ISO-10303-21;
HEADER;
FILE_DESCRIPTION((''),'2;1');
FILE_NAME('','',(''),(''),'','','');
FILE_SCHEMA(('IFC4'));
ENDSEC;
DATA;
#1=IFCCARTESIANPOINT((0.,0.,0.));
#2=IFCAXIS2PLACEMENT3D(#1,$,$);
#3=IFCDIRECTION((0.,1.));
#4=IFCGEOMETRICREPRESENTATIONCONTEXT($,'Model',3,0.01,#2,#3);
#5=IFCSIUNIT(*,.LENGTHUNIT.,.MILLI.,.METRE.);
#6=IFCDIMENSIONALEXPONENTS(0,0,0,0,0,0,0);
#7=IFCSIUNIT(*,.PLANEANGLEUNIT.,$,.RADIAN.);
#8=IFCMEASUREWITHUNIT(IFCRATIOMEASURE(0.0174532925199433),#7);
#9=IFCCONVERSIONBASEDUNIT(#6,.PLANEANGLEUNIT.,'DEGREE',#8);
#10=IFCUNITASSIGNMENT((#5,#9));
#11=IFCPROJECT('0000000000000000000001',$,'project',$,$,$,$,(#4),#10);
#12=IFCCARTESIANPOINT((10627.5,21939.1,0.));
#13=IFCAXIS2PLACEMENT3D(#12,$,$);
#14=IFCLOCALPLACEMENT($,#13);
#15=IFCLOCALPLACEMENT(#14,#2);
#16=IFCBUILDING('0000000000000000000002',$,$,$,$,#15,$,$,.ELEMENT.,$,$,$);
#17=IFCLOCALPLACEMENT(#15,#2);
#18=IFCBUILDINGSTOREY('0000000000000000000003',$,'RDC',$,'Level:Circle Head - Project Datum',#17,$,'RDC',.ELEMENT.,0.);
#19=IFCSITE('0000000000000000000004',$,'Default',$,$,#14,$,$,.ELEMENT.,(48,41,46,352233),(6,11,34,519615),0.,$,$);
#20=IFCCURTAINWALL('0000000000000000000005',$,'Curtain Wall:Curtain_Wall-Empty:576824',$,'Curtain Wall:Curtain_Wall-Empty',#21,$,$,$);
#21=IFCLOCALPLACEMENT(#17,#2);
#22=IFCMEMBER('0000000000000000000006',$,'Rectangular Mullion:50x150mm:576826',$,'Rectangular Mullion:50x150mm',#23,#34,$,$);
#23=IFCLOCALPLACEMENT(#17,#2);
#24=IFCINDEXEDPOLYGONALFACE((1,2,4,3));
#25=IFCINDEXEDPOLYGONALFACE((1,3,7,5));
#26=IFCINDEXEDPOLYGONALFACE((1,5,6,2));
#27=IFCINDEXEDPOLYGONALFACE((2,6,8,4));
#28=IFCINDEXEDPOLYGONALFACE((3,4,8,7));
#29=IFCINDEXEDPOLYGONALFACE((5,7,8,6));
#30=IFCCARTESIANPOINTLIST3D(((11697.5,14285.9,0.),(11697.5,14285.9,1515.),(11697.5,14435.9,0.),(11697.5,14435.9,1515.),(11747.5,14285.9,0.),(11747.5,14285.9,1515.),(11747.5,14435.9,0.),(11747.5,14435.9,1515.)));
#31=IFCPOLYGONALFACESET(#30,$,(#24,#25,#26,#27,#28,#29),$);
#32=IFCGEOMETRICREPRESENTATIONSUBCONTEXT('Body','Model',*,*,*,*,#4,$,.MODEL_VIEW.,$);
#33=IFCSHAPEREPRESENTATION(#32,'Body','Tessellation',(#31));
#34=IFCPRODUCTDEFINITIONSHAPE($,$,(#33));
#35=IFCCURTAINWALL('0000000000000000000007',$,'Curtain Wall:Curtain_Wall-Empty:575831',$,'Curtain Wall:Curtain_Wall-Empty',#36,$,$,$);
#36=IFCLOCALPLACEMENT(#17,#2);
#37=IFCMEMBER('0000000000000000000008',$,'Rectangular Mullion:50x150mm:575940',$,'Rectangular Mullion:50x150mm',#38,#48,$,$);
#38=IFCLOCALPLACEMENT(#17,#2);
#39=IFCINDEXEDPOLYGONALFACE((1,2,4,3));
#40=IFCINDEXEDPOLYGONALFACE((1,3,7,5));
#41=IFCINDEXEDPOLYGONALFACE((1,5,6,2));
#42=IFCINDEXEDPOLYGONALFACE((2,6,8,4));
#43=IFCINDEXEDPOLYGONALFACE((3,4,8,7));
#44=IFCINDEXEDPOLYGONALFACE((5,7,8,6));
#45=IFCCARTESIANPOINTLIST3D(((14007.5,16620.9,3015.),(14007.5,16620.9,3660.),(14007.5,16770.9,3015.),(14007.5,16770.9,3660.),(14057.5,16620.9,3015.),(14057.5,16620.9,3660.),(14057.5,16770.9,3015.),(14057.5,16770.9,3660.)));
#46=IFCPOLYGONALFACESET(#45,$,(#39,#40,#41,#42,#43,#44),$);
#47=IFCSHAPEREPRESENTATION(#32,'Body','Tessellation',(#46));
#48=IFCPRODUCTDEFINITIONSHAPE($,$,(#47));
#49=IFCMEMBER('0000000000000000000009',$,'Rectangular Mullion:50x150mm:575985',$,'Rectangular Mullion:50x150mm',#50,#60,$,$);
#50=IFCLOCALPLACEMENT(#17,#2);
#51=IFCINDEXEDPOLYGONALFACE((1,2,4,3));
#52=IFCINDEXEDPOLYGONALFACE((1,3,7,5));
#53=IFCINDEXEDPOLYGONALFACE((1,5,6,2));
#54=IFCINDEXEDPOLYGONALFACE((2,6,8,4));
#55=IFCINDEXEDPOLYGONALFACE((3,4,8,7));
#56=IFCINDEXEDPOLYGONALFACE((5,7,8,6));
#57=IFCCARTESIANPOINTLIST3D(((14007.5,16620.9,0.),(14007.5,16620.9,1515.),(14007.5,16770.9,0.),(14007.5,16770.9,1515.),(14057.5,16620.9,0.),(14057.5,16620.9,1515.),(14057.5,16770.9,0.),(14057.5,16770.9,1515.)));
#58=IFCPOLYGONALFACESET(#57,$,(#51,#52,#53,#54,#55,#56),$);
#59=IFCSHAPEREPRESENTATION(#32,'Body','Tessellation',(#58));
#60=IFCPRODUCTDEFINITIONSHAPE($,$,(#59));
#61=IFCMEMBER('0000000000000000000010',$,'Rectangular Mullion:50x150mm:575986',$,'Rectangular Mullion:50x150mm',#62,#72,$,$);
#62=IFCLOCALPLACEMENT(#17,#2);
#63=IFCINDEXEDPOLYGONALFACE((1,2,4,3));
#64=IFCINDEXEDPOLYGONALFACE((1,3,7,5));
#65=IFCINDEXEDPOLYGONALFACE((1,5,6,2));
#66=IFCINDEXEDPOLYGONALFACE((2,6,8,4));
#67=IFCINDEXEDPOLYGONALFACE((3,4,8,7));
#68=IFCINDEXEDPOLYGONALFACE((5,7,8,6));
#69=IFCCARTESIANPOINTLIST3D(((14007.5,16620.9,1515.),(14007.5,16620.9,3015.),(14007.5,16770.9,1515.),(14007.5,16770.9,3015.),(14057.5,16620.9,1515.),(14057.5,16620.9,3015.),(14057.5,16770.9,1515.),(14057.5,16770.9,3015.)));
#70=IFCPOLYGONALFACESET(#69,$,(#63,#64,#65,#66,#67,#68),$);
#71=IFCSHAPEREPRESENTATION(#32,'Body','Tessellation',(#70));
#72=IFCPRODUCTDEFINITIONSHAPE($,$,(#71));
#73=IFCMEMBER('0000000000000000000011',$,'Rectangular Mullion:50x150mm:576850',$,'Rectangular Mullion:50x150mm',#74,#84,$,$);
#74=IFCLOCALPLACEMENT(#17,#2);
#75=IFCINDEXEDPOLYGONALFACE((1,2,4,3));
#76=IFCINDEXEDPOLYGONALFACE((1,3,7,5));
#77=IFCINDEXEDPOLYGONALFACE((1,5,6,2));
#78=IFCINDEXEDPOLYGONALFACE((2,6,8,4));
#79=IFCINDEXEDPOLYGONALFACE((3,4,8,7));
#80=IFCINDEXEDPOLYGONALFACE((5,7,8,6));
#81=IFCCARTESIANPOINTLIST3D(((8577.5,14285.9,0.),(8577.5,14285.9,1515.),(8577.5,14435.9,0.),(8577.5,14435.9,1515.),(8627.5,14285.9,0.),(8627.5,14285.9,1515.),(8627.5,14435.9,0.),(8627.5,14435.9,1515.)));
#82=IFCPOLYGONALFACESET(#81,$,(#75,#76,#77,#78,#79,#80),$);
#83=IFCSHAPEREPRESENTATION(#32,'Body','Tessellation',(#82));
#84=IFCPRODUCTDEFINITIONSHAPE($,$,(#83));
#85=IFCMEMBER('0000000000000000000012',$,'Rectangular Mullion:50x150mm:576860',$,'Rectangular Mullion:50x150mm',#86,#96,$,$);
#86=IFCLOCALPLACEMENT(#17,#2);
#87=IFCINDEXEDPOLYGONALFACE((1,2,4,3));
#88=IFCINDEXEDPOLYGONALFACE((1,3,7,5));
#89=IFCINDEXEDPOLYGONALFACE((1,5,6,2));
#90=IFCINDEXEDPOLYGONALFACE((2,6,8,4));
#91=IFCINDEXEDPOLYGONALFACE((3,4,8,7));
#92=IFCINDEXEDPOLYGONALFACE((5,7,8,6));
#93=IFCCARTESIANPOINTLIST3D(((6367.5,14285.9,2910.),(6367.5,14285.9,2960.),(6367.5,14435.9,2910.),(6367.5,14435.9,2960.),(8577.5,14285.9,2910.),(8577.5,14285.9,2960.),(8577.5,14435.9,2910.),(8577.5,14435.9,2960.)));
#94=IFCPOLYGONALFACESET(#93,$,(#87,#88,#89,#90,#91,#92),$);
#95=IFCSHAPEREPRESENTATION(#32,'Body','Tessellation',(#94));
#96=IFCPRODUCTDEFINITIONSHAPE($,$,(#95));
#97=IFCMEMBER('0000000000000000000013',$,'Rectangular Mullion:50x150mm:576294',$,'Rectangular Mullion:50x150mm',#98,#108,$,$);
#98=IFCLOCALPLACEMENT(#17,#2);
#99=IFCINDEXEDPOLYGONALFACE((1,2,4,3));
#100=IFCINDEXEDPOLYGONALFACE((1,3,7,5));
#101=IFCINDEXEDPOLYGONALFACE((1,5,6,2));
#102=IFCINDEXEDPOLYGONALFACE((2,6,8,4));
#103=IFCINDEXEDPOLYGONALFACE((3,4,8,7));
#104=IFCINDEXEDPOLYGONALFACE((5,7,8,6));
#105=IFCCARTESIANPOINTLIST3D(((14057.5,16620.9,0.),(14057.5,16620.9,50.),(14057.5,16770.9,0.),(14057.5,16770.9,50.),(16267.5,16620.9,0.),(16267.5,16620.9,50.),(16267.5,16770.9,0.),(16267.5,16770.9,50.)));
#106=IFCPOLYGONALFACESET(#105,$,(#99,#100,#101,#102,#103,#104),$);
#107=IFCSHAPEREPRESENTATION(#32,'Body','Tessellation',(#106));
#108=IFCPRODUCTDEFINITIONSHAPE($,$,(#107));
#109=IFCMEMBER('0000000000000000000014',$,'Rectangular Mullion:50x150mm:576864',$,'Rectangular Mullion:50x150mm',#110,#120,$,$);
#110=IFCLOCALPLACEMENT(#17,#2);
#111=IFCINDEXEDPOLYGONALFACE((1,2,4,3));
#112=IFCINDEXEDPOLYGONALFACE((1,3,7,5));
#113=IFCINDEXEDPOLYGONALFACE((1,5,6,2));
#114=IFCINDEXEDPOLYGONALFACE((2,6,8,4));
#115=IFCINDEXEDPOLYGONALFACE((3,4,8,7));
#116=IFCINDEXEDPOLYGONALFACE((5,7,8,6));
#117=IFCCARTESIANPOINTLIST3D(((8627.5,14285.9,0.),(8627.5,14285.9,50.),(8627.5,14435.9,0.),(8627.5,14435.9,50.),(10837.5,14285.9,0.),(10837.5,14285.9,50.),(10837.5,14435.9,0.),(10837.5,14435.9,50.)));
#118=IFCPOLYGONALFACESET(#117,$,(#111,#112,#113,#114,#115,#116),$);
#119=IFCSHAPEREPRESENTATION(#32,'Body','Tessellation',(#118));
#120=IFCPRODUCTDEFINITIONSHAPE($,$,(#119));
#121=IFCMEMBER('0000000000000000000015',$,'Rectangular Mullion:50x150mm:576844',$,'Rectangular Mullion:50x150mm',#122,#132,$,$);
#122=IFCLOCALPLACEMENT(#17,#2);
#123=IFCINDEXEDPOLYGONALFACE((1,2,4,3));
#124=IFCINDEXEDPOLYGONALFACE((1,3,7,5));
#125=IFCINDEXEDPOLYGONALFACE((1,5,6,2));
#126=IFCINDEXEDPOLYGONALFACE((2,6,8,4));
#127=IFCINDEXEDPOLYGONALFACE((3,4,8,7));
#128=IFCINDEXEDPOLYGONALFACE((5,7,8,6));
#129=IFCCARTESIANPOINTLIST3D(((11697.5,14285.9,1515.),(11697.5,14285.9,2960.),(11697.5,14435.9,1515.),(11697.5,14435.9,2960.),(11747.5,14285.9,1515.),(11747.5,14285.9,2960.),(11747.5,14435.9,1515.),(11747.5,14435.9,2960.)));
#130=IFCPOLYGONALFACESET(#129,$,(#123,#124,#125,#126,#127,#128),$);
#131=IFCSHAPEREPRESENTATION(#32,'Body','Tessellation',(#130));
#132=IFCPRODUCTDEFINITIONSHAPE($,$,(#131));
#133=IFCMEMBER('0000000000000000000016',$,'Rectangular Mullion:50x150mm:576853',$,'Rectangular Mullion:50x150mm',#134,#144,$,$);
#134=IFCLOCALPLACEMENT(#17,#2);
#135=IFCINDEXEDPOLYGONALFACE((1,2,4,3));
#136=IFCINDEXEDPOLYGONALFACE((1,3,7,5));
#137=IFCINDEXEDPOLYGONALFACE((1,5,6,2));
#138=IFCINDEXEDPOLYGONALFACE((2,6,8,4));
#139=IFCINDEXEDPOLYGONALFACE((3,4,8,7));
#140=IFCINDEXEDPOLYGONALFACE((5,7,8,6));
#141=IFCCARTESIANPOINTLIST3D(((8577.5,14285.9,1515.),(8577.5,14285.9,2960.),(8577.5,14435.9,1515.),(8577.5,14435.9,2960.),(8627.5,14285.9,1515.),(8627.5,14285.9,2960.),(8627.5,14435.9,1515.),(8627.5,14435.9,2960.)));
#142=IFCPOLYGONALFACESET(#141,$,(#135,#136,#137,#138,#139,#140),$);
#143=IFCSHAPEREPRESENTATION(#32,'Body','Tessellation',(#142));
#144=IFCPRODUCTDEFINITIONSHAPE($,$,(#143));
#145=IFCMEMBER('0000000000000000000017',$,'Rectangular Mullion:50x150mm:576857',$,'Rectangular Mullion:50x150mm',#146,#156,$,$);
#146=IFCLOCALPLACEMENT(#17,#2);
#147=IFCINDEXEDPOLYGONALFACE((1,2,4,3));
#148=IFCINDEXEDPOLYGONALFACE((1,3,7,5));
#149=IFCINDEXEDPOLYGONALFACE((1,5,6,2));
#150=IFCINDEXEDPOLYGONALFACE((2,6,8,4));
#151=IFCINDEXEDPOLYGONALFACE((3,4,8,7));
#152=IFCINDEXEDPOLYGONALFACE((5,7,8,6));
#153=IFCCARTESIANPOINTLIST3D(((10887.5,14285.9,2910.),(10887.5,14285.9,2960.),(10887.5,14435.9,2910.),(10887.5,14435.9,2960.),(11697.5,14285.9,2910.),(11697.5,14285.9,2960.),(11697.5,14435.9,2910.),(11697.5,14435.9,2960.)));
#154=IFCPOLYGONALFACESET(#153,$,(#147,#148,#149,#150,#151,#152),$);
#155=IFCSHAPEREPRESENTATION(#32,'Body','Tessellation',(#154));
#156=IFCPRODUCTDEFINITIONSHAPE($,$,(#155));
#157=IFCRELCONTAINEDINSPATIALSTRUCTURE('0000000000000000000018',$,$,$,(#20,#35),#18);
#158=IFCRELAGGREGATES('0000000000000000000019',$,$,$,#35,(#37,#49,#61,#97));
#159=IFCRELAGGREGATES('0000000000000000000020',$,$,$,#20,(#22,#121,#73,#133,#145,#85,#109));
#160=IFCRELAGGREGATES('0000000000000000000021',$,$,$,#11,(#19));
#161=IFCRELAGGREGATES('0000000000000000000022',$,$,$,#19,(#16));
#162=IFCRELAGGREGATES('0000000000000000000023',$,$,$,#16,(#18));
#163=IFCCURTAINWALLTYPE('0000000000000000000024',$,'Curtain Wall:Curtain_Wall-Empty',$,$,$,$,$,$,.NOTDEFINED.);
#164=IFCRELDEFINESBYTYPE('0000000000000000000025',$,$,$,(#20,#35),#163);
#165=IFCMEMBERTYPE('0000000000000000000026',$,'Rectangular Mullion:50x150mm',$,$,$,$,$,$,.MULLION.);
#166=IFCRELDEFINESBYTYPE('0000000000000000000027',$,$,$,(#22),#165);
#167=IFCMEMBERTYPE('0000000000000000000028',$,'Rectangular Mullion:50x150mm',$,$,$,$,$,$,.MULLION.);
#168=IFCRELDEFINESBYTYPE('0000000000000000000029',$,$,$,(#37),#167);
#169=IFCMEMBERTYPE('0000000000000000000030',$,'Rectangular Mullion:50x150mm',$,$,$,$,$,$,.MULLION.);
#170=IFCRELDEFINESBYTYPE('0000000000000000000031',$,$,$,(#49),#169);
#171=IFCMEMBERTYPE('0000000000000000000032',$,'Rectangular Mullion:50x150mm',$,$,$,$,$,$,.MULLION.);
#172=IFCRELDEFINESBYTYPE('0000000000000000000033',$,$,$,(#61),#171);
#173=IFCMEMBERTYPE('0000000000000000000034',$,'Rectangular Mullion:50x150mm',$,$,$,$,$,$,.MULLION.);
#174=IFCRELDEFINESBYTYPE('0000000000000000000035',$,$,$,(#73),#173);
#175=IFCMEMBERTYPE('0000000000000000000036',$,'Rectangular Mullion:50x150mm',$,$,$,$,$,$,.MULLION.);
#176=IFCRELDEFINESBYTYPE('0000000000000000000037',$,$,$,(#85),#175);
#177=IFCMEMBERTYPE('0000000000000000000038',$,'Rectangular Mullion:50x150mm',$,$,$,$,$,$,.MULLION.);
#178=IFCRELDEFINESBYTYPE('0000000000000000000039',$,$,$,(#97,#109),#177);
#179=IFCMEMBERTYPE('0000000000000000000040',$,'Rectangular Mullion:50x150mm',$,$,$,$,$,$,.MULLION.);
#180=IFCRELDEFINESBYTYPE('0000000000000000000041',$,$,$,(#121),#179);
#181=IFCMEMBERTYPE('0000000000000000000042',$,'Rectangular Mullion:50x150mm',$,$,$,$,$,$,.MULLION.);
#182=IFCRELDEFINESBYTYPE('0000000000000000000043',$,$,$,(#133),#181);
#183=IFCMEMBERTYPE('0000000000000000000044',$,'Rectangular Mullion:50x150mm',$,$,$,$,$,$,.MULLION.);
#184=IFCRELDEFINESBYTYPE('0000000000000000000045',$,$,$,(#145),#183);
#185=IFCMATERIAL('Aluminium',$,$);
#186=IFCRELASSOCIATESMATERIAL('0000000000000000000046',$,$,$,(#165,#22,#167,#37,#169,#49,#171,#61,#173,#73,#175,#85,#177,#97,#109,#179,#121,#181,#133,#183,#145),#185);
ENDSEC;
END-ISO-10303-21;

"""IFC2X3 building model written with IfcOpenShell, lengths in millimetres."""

from ifc_helpers import new_model, entity, si_unit, converted_unit, direction, frame, origin, origin_2d_with_axis, place, context, subcontext, project, spatial, rectangle, extrude, source, transform, mapped, material, type_object, type_shapes, element, aggregate, save


model = new_model("IFC2X3")

# Units and contexts
model_context = context("Model", 3, precision=0.01, world=origin(), true_north=direction((0.0, 1.0)))
body_context = subcontext(model_context, "Body", "Model", "MODEL_VIEW")
ifc_project = project(units=[si_unit("LENGTHUNIT", "METRE", prefix="MILLI"), converted_unit("PLANEANGLEUNIT", "DEGREE", entity("IfcRatioMeasure", 0.0174532925199433), si_unit("PLANEANGLEUNIT", "RADIAN"), dimensions=[0, 0, 0, 0, 0, 0, 0])], contexts=[model_context])

# Site, building, storey
site_placement = place(None, frame((10627.5, 21939.1, 0.0)))
site = spatial("IfcSite", under=ifc_project, at=site_placement, Name="Default", CompositionType="ELEMENT", RefLatitude=(48, 41, 46, 352233), RefLongitude=(6, 11, 34, 519615), RefElevation=0.0)
building_placement = place(site_placement, origin())
building = spatial("IfcBuilding", under=site, at=building_placement, CompositionType="ELEMENT")
storey_placement = place(building_placement, origin())
storey = spatial("IfcBuildingStorey", under=building, at=storey_placement, Name="RDC", ObjectType="Level:Circle Head - Project Datum", LongName="RDC", CompositionType="ELEMENT", Elevation=0.0)

# Curtain wall, member
curtain_wall_type = type_object("IfcCurtainWallType", Name="Curtain Wall:Curtain_Wall-Empty", PredefinedType="NOTDEFINED")
curtain_wall_1_placement = place(storey_placement, origin())
curtain_wall_1 = element("IfcCurtainWall", 1, at=curtain_wall_1_placement, inside=storey, type_object=curtain_wall_type, Name="Curtain Wall:Curtain_Wall-Empty:576824", ObjectType="Curtain Wall:Curtain_Wall-Empty")
ifc_material_1 = material(Name="Aluminium")
member_type_1 = type_object("IfcMemberType", Name="Rectangular Mullion:50x150mm", PredefinedType="MULLION", material=ifc_material_1)
shared_shape_1 = source(origin(), body_context, "Body", "SweptSolid", [
    extrude(rectangle(XDim=150.0, YDim=50.0, at=origin_2d_with_axis()), frame((-25.0, 0.0, -1515.0), z_axis=(0.0, 0.0, 1.0), x_axis=(0.0, -1.0, 0.0)), (0.0, 0.0, 1.0), 1515.0),
])
type_shapes(member_type_1, [shared_shape_1])
member_1_placement = place(storey_placement, frame((11747.5, 14360.9, 0.0), z_axis=(0.0, 0.0, -1.0), x_axis=(1.0, 0.0, 0.0)))
member_1 = element("IfcMember", 2, at=member_1_placement, type_object=member_type_1, material=ifc_material_1, Name="Rectangular Mullion:50x150mm:576826", ObjectType="Rectangular Mullion:50x150mm", context=body_context, shape_type="MappedRepresentation", body=[
    mapped(shared_shape_1, transform((0.0, 0.0, 0.0), scale=1.0)),
])

# Curtain wall, members
curtain_wall_2_placement = place(storey_placement, origin())
curtain_wall_2 = element("IfcCurtainWall", 3, at=curtain_wall_2_placement, inside=storey, type_object=curtain_wall_type, Name="Curtain Wall:Curtain_Wall-Empty:575831", ObjectType="Curtain Wall:Curtain_Wall-Empty")
member_type_2 = type_object("IfcMemberType", Name="Rectangular Mullion:50x150mm", PredefinedType="MULLION", material=ifc_material_1)
shared_shape_2 = source(origin(), body_context, "Body", "SweptSolid", [
    extrude(rectangle(XDim=150.0, YDim=50.0, at=origin_2d_with_axis()), frame((-25.0, 0.0, -645.0), z_axis=(0.0, 0.0, 1.0), x_axis=(0.0, -1.0, 0.0)), (0.0, 0.0, 1.0), 645.0),
])
type_shapes(member_type_2, [shared_shape_2])
member_2_placement = place(storey_placement, frame((14007.5, 16695.9, 3660.0), z_axis=(0.0, 0.0, 1.0), x_axis=(-1.0, 0.0, 0.0)))
member_2 = element("IfcMember", 4, at=member_2_placement, type_object=member_type_2, material=ifc_material_1, Name="Rectangular Mullion:50x150mm:575940", ObjectType="Rectangular Mullion:50x150mm", context=body_context, shape_type="MappedRepresentation", body=[
    mapped(shared_shape_2, transform((0.0, 0.0, 0.0), scale=1.0)),
])
member_type_3 = type_object("IfcMemberType", Name="Rectangular Mullion:50x150mm", PredefinedType="MULLION", material=ifc_material_1)
shared_shape_3 = source(origin(), body_context, "Body", "SweptSolid", [
    extrude(rectangle(XDim=150.0, YDim=50.0, at=origin_2d_with_axis()), frame((-25.0, 0.0, -1515.0), z_axis=(0.0, 0.0, 1.0), x_axis=(0.0, -1.0, 0.0)), (0.0, 0.0, 1.0), 1515.0),
])
type_shapes(member_type_3, [shared_shape_3])
member_3_placement = place(storey_placement, frame((14007.5, 16695.9, 1515.0), z_axis=(0.0, 0.0, 1.0), x_axis=(-1.0, 0.0, 0.0)))
member_3 = element("IfcMember", 5, at=member_3_placement, type_object=member_type_3, material=ifc_material_1, Name="Rectangular Mullion:50x150mm:575985", ObjectType="Rectangular Mullion:50x150mm", context=body_context, shape_type="MappedRepresentation", body=[
    mapped(shared_shape_3, transform((0.0, 0.0, 0.0), scale=1.0)),
])
member_type_4 = type_object("IfcMemberType", Name="Rectangular Mullion:50x150mm", PredefinedType="MULLION", material=ifc_material_1)
shared_shape_4 = source(origin(), body_context, "Body", "SweptSolid", [
    extrude(rectangle(XDim=150.0, YDim=50.0, at=origin_2d_with_axis()), frame((-25.0, 0.0, -1500.0), z_axis=(0.0, 0.0, 1.0), x_axis=(0.0, -1.0, 0.0)), (0.0, 0.0, 1.0), 1500.0),
])
type_shapes(member_type_4, [shared_shape_4])
member_4_placement = place(storey_placement, frame((14007.5, 16695.9, 3015.0), z_axis=(0.0, 0.0, 1.0), x_axis=(-1.0, 0.0, 0.0)))
member_4 = element("IfcMember", 6, at=member_4_placement, type_object=member_type_4, material=ifc_material_1, Name="Rectangular Mullion:50x150mm:575986", ObjectType="Rectangular Mullion:50x150mm", context=body_context, shape_type="MappedRepresentation", body=[
    mapped(shared_shape_4, transform((0.0, 0.0, 0.0), scale=1.0)),
])

# Members
member_type_5 = type_object("IfcMemberType", Name="Rectangular Mullion:50x150mm", PredefinedType="MULLION", material=ifc_material_1)
shared_shape_5 = source(origin(), body_context, "Body", "SweptSolid", [
    extrude(rectangle(XDim=150.0, YDim=50.0, at=origin_2d_with_axis()), frame((0.0, 0.0, -1515.0), z_axis=(0.0, 0.0, 1.0), x_axis=(0.0, -1.0, 0.0)), (0.0, 0.0, 1.0), 1515.0),
])
type_shapes(member_type_5, [shared_shape_5])
member_5_placement = place(storey_placement, frame((8602.5, 14360.9, 0.0), z_axis=(0.0, 0.0, -1.0), x_axis=(1.0, 0.0, 0.0)))
member_5 = element("IfcMember", 7, at=member_5_placement, type_object=member_type_5, material=ifc_material_1, Name="Rectangular Mullion:50x150mm:576850", ObjectType="Rectangular Mullion:50x150mm", context=body_context, shape_type="MappedRepresentation", body=[
    mapped(shared_shape_5, transform((0.0, 0.0, 0.0), scale=1.0)),
])
member_type_6 = type_object("IfcMemberType", Name="Rectangular Mullion:50x150mm", PredefinedType="MULLION", material=ifc_material_1)
shared_shape_6 = source(origin(), body_context, "Body", "SweptSolid", [
    extrude(rectangle(XDim=150.0, YDim=50.0, at=origin_2d_with_axis()), frame((-25.0, 0.0, -2210.0), z_axis=(0.0, 0.0, 1.0), x_axis=(0.0, -1.0, 0.0)), (0.0, 0.0, 1.0), 2210.0),
])
type_shapes(member_type_6, [shared_shape_6])
member_6_placement = place(storey_placement, frame((8577.5, 14360.9, 2960.0), z_axis=(1.0, 0.0, 0.0), x_axis=(0.0, 0.0, 1.0)))
member_6 = element("IfcMember", 8, at=member_6_placement, type_object=member_type_6, material=ifc_material_1, Name="Rectangular Mullion:50x150mm:576860", ObjectType="Rectangular Mullion:50x150mm", context=body_context, shape_type="MappedRepresentation", body=[
    mapped(shared_shape_6, transform((0.0, 0.0, 0.0), scale=1.0)),
])
member_type_7 = type_object("IfcMemberType", Name="Rectangular Mullion:50x150mm", PredefinedType="MULLION", material=ifc_material_1)
shared_shape_7 = source(origin(), body_context, "Body", "SweptSolid", [
    extrude(rectangle(XDim=150.0, YDim=50.0, at=origin_2d_with_axis()), frame((-25.0, 0.0, -2210.0), z_axis=(0.0, 0.0, 1.0), x_axis=(0.0, -1.0, 0.0)), (0.0, 0.0, 1.0), 2210.0),
])
type_shapes(member_type_7, [shared_shape_7])
member_7_placement = place(storey_placement, frame((14057.5, 16695.9, 0.0), z_axis=(-1.0, 0.0, 0.0), x_axis=(0.0, 0.0, -1.0)))
member_7 = element("IfcMember", 9, at=member_7_placement, type_object=member_type_7, material=ifc_material_1, Name="Rectangular Mullion:50x150mm:576294", ObjectType="Rectangular Mullion:50x150mm", context=body_context, shape_type="MappedRepresentation", body=[
    mapped(shared_shape_7, transform((0.0, 0.0, 0.0), scale=1.0)),
])
aggregate(curtain_wall_2, [member_2, member_3, member_4, member_7])
member_8_placement = place(storey_placement, frame((8627.5, 14360.9, 0.0), z_axis=(-1.0, 0.0, 0.0), x_axis=(0.0, 0.0, -1.0)))
member_8 = element("IfcMember", 10, at=member_8_placement, type_object=member_type_7, material=ifc_material_1, Name="Rectangular Mullion:50x150mm:576864", ObjectType="Rectangular Mullion:50x150mm", context=body_context, shape_type="MappedRepresentation", body=[
    mapped(shared_shape_7, transform((0.0, 0.0, 0.0), scale=1.0)),
])
member_type_8 = type_object("IfcMemberType", Name="Rectangular Mullion:50x150mm", PredefinedType="MULLION", material=ifc_material_1)
shared_shape_8 = source(origin(), body_context, "Body", "SweptSolid", [
    extrude(rectangle(XDim=150.0, YDim=50.0, at=origin_2d_with_axis()), frame((-25.0, 0.0, -1445.0), z_axis=(0.0, 0.0, 1.0), x_axis=(0.0, -1.0, 0.0)), (0.0, 0.0, 1.0), 1445.0),
])
type_shapes(member_type_8, [shared_shape_8])
member_9_placement = place(storey_placement, frame((11747.5, 14360.9, 1515.0), z_axis=(0.0, 0.0, -1.0), x_axis=(1.0, 0.0, 0.0)))
member_9 = element("IfcMember", 11, at=member_9_placement, type_object=member_type_8, material=ifc_material_1, Name="Rectangular Mullion:50x150mm:576844", ObjectType="Rectangular Mullion:50x150mm", context=body_context, shape_type="MappedRepresentation", body=[
    mapped(shared_shape_8, transform((0.0, 0.0, 0.0), scale=1.0)),
])
member_type_9 = type_object("IfcMemberType", Name="Rectangular Mullion:50x150mm", PredefinedType="MULLION", material=ifc_material_1)
shared_shape_9 = source(origin(), body_context, "Body", "SweptSolid", [
    extrude(rectangle(XDim=150.0, YDim=50.0, at=origin_2d_with_axis()), frame((0.0, 0.0, -1445.0), z_axis=(0.0, 0.0, 1.0), x_axis=(0.0, -1.0, 0.0)), (0.0, 0.0, 1.0), 1445.0),
])
type_shapes(member_type_9, [shared_shape_9])
member_10_placement = place(storey_placement, frame((8602.5, 14360.9, 1515.0), z_axis=(0.0, 0.0, -1.0), x_axis=(1.0, 0.0, 0.0)))
member_10 = element("IfcMember", 12, at=member_10_placement, type_object=member_type_9, material=ifc_material_1, Name="Rectangular Mullion:50x150mm:576853", ObjectType="Rectangular Mullion:50x150mm", context=body_context, shape_type="MappedRepresentation", body=[
    mapped(shared_shape_9, transform((0.0, 0.0, 0.0), scale=1.0)),
])
member_type_10 = type_object("IfcMemberType", Name="Rectangular Mullion:50x150mm", PredefinedType="MULLION", material=ifc_material_1)
shared_shape_10 = source(origin(), body_context, "Body", "SweptSolid", [
    extrude(rectangle(XDim=150.0, YDim=50.0, at=origin_2d_with_axis()), frame((-25.0, 0.0, -810.0), z_axis=(0.0, 0.0, 1.0), x_axis=(0.0, -1.0, 0.0)), (0.0, 0.0, 1.0), 810.0),
])
type_shapes(member_type_10, [shared_shape_10])
member_11_placement = place(storey_placement, frame((11697.5, 14360.9, 2960.0), z_axis=(1.0, 0.0, 0.0), x_axis=(0.0, 0.0, 1.0)))
member_11 = element("IfcMember", 13, at=member_11_placement, type_object=member_type_10, material=ifc_material_1, Name="Rectangular Mullion:50x150mm:576857", ObjectType="Rectangular Mullion:50x150mm", context=body_context, shape_type="MappedRepresentation", body=[
    mapped(shared_shape_10, transform((0.0, 0.0, 0.0), scale=1.0)),
])

aggregate(curtain_wall_1, [member_1, member_9, member_5, member_10, member_11, member_6, member_8])

save(model, "model.ifc")
